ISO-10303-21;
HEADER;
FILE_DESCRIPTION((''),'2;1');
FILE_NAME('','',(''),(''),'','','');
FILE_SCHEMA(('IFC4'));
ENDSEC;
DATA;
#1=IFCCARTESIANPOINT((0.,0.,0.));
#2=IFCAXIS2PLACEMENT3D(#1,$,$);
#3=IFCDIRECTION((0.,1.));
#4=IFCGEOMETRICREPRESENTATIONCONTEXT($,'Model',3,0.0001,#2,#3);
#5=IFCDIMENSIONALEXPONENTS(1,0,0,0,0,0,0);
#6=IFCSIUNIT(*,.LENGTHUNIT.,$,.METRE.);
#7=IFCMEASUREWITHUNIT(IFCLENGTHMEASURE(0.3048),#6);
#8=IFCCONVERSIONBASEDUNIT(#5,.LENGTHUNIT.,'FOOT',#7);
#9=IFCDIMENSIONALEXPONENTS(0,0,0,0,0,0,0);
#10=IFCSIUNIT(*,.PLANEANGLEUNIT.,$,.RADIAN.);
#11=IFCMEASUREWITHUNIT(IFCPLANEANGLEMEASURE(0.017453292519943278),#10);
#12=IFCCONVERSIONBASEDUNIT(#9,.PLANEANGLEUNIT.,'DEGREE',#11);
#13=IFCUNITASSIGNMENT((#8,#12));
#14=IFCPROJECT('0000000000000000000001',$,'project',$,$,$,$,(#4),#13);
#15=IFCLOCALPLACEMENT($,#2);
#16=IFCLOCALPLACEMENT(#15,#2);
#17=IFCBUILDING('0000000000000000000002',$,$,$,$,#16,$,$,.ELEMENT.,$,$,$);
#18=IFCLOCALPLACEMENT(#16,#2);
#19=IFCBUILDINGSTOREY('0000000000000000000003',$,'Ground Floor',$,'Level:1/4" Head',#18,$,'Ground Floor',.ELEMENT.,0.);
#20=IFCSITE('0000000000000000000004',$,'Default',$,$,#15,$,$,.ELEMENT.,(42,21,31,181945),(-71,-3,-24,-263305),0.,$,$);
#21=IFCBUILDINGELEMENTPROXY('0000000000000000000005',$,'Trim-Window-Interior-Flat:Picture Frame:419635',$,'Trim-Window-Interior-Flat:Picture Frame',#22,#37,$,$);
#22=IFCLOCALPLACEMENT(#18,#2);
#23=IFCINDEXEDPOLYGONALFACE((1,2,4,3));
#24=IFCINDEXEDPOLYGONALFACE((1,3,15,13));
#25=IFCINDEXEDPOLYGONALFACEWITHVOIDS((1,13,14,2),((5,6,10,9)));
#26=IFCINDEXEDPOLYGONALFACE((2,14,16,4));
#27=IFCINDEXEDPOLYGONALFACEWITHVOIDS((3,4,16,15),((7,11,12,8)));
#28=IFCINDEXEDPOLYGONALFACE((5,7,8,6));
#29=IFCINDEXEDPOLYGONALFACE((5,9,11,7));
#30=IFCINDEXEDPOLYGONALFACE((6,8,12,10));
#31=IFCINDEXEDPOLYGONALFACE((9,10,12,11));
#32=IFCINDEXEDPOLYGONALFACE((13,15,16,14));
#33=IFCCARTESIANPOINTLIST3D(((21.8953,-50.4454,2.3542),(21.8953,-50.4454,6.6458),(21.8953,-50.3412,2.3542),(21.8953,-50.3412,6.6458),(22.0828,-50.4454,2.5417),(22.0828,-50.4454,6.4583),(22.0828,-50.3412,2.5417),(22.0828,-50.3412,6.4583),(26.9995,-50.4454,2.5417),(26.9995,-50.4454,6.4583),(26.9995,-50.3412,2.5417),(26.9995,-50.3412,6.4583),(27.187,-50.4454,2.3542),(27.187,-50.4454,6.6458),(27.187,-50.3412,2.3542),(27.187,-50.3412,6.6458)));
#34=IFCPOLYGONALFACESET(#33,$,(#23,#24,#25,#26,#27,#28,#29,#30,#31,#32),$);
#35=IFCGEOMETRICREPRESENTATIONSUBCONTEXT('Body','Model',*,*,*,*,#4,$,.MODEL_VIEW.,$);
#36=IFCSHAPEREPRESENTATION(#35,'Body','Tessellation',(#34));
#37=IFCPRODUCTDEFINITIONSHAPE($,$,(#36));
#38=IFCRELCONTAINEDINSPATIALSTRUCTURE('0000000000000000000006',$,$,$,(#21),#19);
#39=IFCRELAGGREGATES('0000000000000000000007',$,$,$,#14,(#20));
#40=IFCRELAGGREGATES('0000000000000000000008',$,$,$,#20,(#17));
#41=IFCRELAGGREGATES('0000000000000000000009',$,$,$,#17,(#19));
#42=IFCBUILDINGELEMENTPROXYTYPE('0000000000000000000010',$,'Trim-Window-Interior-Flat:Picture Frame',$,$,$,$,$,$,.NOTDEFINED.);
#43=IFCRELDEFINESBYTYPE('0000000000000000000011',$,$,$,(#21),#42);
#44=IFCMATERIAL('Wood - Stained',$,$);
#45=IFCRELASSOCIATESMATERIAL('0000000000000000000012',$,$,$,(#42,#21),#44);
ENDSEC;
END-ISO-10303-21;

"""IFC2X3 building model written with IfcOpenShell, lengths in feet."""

from ifc_helpers import new_model, entity, si_unit, converted_unit, direction, frame, origin, place, context, subcontext, project, spatial, polyline, outline, extrude, source, transform, mapped, material, type_object, type_shapes, element, save


model = new_model("IFC2X3")

# Units and contexts
model_context = context("Model", 3, precision=0.0001, world=origin(), true_north=direction((0.0, 1.0)))
body_context = subcontext(model_context, "Body", "Model", "MODEL_VIEW")
ifc_project = project(units=[converted_unit("LENGTHUNIT", "FOOT", entity("IfcLengthMeasure", 0.3048), si_unit("LENGTHUNIT", "METRE"), dimensions=[1, 0, 0, 0, 0, 0, 0]), converted_unit("PLANEANGLEUNIT", "DEGREE", entity("IfcPlaneAngleMeasure", 0.017453292519943278), si_unit("PLANEANGLEUNIT", "RADIAN"), dimensions=[0, 0, 0, 0, 0, 0, 0])], contexts=[model_context])

# Site, building, storey
site_placement = place(None, origin())
site = spatial("IfcSite", under=ifc_project, at=site_placement, Name="Default", CompositionType="ELEMENT", RefLatitude=(42, 21, 31, 181945), RefLongitude=(-71, -3, -24, -263305), RefElevation=0.0)
building_placement = place(site_placement, origin())
building = spatial("IfcBuilding", under=site, at=building_placement, CompositionType="ELEMENT")
storey_placement = place(building_placement, origin())
storey = spatial("IfcBuildingStorey", under=building, at=storey_placement, Name="Ground Floor", ObjectType="Level:1/4\" Head", LongName="Ground Floor", CompositionType="ELEMENT", Elevation=0.0)

# Building element proxy
ifc_material_1 = material(Name="Wood - Stained")
building_element_proxy_type_1 = type_object("IfcBuildingElementProxyType", Name="Trim-Window-Interior-Flat:Picture Frame", PredefinedType="NOTDEFINED", material=ifc_material_1)
shared_shape_1 = source(origin(), body_context, "Body", "SweptSolid", [
    extrude(outline(polyline([(-2.6458, -2.1458), (2.6458, -2.1458), (2.6458, 2.1458), (-2.6458, 2.1458), (-2.6458, -2.1458)]), holes=[polyline([(-2.4583, -1.9583), (-2.4583, 1.9583), (2.4583, 1.9583), (2.4583, -1.9583), (-2.4583, -1.9583)])]), frame((0.0, -2.0, 0.0), z_axis=(0.0, 0.0, 1.0), x_axis=(-1.0, 0.0, 0.0)), (0.0, 0.0, 1.0), 0.1042),
])
type_shapes(building_element_proxy_type_1, [shared_shape_1])
proxy_1_placement = place(storey_placement, frame((24.5411, -50.3412, 6.5), z_axis=(0.0, -1.0, 0.0), x_axis=(1.0, 0.0, 0.0)))
element("IfcBuildingElementProxy", 1, at=proxy_1_placement, inside=storey, type_object=building_element_proxy_type_1, material=ifc_material_1, Name="Trim-Window-Interior-Flat:Picture Frame:419635", ObjectType="Trim-Window-Interior-Flat:Picture Frame", context=body_context, shape_type="MappedRepresentation", body=[
    mapped(shared_shape_1, transform((0.0, 0.0, 0.0), scale=1.0)),
])

save(model, "model.ifc")
